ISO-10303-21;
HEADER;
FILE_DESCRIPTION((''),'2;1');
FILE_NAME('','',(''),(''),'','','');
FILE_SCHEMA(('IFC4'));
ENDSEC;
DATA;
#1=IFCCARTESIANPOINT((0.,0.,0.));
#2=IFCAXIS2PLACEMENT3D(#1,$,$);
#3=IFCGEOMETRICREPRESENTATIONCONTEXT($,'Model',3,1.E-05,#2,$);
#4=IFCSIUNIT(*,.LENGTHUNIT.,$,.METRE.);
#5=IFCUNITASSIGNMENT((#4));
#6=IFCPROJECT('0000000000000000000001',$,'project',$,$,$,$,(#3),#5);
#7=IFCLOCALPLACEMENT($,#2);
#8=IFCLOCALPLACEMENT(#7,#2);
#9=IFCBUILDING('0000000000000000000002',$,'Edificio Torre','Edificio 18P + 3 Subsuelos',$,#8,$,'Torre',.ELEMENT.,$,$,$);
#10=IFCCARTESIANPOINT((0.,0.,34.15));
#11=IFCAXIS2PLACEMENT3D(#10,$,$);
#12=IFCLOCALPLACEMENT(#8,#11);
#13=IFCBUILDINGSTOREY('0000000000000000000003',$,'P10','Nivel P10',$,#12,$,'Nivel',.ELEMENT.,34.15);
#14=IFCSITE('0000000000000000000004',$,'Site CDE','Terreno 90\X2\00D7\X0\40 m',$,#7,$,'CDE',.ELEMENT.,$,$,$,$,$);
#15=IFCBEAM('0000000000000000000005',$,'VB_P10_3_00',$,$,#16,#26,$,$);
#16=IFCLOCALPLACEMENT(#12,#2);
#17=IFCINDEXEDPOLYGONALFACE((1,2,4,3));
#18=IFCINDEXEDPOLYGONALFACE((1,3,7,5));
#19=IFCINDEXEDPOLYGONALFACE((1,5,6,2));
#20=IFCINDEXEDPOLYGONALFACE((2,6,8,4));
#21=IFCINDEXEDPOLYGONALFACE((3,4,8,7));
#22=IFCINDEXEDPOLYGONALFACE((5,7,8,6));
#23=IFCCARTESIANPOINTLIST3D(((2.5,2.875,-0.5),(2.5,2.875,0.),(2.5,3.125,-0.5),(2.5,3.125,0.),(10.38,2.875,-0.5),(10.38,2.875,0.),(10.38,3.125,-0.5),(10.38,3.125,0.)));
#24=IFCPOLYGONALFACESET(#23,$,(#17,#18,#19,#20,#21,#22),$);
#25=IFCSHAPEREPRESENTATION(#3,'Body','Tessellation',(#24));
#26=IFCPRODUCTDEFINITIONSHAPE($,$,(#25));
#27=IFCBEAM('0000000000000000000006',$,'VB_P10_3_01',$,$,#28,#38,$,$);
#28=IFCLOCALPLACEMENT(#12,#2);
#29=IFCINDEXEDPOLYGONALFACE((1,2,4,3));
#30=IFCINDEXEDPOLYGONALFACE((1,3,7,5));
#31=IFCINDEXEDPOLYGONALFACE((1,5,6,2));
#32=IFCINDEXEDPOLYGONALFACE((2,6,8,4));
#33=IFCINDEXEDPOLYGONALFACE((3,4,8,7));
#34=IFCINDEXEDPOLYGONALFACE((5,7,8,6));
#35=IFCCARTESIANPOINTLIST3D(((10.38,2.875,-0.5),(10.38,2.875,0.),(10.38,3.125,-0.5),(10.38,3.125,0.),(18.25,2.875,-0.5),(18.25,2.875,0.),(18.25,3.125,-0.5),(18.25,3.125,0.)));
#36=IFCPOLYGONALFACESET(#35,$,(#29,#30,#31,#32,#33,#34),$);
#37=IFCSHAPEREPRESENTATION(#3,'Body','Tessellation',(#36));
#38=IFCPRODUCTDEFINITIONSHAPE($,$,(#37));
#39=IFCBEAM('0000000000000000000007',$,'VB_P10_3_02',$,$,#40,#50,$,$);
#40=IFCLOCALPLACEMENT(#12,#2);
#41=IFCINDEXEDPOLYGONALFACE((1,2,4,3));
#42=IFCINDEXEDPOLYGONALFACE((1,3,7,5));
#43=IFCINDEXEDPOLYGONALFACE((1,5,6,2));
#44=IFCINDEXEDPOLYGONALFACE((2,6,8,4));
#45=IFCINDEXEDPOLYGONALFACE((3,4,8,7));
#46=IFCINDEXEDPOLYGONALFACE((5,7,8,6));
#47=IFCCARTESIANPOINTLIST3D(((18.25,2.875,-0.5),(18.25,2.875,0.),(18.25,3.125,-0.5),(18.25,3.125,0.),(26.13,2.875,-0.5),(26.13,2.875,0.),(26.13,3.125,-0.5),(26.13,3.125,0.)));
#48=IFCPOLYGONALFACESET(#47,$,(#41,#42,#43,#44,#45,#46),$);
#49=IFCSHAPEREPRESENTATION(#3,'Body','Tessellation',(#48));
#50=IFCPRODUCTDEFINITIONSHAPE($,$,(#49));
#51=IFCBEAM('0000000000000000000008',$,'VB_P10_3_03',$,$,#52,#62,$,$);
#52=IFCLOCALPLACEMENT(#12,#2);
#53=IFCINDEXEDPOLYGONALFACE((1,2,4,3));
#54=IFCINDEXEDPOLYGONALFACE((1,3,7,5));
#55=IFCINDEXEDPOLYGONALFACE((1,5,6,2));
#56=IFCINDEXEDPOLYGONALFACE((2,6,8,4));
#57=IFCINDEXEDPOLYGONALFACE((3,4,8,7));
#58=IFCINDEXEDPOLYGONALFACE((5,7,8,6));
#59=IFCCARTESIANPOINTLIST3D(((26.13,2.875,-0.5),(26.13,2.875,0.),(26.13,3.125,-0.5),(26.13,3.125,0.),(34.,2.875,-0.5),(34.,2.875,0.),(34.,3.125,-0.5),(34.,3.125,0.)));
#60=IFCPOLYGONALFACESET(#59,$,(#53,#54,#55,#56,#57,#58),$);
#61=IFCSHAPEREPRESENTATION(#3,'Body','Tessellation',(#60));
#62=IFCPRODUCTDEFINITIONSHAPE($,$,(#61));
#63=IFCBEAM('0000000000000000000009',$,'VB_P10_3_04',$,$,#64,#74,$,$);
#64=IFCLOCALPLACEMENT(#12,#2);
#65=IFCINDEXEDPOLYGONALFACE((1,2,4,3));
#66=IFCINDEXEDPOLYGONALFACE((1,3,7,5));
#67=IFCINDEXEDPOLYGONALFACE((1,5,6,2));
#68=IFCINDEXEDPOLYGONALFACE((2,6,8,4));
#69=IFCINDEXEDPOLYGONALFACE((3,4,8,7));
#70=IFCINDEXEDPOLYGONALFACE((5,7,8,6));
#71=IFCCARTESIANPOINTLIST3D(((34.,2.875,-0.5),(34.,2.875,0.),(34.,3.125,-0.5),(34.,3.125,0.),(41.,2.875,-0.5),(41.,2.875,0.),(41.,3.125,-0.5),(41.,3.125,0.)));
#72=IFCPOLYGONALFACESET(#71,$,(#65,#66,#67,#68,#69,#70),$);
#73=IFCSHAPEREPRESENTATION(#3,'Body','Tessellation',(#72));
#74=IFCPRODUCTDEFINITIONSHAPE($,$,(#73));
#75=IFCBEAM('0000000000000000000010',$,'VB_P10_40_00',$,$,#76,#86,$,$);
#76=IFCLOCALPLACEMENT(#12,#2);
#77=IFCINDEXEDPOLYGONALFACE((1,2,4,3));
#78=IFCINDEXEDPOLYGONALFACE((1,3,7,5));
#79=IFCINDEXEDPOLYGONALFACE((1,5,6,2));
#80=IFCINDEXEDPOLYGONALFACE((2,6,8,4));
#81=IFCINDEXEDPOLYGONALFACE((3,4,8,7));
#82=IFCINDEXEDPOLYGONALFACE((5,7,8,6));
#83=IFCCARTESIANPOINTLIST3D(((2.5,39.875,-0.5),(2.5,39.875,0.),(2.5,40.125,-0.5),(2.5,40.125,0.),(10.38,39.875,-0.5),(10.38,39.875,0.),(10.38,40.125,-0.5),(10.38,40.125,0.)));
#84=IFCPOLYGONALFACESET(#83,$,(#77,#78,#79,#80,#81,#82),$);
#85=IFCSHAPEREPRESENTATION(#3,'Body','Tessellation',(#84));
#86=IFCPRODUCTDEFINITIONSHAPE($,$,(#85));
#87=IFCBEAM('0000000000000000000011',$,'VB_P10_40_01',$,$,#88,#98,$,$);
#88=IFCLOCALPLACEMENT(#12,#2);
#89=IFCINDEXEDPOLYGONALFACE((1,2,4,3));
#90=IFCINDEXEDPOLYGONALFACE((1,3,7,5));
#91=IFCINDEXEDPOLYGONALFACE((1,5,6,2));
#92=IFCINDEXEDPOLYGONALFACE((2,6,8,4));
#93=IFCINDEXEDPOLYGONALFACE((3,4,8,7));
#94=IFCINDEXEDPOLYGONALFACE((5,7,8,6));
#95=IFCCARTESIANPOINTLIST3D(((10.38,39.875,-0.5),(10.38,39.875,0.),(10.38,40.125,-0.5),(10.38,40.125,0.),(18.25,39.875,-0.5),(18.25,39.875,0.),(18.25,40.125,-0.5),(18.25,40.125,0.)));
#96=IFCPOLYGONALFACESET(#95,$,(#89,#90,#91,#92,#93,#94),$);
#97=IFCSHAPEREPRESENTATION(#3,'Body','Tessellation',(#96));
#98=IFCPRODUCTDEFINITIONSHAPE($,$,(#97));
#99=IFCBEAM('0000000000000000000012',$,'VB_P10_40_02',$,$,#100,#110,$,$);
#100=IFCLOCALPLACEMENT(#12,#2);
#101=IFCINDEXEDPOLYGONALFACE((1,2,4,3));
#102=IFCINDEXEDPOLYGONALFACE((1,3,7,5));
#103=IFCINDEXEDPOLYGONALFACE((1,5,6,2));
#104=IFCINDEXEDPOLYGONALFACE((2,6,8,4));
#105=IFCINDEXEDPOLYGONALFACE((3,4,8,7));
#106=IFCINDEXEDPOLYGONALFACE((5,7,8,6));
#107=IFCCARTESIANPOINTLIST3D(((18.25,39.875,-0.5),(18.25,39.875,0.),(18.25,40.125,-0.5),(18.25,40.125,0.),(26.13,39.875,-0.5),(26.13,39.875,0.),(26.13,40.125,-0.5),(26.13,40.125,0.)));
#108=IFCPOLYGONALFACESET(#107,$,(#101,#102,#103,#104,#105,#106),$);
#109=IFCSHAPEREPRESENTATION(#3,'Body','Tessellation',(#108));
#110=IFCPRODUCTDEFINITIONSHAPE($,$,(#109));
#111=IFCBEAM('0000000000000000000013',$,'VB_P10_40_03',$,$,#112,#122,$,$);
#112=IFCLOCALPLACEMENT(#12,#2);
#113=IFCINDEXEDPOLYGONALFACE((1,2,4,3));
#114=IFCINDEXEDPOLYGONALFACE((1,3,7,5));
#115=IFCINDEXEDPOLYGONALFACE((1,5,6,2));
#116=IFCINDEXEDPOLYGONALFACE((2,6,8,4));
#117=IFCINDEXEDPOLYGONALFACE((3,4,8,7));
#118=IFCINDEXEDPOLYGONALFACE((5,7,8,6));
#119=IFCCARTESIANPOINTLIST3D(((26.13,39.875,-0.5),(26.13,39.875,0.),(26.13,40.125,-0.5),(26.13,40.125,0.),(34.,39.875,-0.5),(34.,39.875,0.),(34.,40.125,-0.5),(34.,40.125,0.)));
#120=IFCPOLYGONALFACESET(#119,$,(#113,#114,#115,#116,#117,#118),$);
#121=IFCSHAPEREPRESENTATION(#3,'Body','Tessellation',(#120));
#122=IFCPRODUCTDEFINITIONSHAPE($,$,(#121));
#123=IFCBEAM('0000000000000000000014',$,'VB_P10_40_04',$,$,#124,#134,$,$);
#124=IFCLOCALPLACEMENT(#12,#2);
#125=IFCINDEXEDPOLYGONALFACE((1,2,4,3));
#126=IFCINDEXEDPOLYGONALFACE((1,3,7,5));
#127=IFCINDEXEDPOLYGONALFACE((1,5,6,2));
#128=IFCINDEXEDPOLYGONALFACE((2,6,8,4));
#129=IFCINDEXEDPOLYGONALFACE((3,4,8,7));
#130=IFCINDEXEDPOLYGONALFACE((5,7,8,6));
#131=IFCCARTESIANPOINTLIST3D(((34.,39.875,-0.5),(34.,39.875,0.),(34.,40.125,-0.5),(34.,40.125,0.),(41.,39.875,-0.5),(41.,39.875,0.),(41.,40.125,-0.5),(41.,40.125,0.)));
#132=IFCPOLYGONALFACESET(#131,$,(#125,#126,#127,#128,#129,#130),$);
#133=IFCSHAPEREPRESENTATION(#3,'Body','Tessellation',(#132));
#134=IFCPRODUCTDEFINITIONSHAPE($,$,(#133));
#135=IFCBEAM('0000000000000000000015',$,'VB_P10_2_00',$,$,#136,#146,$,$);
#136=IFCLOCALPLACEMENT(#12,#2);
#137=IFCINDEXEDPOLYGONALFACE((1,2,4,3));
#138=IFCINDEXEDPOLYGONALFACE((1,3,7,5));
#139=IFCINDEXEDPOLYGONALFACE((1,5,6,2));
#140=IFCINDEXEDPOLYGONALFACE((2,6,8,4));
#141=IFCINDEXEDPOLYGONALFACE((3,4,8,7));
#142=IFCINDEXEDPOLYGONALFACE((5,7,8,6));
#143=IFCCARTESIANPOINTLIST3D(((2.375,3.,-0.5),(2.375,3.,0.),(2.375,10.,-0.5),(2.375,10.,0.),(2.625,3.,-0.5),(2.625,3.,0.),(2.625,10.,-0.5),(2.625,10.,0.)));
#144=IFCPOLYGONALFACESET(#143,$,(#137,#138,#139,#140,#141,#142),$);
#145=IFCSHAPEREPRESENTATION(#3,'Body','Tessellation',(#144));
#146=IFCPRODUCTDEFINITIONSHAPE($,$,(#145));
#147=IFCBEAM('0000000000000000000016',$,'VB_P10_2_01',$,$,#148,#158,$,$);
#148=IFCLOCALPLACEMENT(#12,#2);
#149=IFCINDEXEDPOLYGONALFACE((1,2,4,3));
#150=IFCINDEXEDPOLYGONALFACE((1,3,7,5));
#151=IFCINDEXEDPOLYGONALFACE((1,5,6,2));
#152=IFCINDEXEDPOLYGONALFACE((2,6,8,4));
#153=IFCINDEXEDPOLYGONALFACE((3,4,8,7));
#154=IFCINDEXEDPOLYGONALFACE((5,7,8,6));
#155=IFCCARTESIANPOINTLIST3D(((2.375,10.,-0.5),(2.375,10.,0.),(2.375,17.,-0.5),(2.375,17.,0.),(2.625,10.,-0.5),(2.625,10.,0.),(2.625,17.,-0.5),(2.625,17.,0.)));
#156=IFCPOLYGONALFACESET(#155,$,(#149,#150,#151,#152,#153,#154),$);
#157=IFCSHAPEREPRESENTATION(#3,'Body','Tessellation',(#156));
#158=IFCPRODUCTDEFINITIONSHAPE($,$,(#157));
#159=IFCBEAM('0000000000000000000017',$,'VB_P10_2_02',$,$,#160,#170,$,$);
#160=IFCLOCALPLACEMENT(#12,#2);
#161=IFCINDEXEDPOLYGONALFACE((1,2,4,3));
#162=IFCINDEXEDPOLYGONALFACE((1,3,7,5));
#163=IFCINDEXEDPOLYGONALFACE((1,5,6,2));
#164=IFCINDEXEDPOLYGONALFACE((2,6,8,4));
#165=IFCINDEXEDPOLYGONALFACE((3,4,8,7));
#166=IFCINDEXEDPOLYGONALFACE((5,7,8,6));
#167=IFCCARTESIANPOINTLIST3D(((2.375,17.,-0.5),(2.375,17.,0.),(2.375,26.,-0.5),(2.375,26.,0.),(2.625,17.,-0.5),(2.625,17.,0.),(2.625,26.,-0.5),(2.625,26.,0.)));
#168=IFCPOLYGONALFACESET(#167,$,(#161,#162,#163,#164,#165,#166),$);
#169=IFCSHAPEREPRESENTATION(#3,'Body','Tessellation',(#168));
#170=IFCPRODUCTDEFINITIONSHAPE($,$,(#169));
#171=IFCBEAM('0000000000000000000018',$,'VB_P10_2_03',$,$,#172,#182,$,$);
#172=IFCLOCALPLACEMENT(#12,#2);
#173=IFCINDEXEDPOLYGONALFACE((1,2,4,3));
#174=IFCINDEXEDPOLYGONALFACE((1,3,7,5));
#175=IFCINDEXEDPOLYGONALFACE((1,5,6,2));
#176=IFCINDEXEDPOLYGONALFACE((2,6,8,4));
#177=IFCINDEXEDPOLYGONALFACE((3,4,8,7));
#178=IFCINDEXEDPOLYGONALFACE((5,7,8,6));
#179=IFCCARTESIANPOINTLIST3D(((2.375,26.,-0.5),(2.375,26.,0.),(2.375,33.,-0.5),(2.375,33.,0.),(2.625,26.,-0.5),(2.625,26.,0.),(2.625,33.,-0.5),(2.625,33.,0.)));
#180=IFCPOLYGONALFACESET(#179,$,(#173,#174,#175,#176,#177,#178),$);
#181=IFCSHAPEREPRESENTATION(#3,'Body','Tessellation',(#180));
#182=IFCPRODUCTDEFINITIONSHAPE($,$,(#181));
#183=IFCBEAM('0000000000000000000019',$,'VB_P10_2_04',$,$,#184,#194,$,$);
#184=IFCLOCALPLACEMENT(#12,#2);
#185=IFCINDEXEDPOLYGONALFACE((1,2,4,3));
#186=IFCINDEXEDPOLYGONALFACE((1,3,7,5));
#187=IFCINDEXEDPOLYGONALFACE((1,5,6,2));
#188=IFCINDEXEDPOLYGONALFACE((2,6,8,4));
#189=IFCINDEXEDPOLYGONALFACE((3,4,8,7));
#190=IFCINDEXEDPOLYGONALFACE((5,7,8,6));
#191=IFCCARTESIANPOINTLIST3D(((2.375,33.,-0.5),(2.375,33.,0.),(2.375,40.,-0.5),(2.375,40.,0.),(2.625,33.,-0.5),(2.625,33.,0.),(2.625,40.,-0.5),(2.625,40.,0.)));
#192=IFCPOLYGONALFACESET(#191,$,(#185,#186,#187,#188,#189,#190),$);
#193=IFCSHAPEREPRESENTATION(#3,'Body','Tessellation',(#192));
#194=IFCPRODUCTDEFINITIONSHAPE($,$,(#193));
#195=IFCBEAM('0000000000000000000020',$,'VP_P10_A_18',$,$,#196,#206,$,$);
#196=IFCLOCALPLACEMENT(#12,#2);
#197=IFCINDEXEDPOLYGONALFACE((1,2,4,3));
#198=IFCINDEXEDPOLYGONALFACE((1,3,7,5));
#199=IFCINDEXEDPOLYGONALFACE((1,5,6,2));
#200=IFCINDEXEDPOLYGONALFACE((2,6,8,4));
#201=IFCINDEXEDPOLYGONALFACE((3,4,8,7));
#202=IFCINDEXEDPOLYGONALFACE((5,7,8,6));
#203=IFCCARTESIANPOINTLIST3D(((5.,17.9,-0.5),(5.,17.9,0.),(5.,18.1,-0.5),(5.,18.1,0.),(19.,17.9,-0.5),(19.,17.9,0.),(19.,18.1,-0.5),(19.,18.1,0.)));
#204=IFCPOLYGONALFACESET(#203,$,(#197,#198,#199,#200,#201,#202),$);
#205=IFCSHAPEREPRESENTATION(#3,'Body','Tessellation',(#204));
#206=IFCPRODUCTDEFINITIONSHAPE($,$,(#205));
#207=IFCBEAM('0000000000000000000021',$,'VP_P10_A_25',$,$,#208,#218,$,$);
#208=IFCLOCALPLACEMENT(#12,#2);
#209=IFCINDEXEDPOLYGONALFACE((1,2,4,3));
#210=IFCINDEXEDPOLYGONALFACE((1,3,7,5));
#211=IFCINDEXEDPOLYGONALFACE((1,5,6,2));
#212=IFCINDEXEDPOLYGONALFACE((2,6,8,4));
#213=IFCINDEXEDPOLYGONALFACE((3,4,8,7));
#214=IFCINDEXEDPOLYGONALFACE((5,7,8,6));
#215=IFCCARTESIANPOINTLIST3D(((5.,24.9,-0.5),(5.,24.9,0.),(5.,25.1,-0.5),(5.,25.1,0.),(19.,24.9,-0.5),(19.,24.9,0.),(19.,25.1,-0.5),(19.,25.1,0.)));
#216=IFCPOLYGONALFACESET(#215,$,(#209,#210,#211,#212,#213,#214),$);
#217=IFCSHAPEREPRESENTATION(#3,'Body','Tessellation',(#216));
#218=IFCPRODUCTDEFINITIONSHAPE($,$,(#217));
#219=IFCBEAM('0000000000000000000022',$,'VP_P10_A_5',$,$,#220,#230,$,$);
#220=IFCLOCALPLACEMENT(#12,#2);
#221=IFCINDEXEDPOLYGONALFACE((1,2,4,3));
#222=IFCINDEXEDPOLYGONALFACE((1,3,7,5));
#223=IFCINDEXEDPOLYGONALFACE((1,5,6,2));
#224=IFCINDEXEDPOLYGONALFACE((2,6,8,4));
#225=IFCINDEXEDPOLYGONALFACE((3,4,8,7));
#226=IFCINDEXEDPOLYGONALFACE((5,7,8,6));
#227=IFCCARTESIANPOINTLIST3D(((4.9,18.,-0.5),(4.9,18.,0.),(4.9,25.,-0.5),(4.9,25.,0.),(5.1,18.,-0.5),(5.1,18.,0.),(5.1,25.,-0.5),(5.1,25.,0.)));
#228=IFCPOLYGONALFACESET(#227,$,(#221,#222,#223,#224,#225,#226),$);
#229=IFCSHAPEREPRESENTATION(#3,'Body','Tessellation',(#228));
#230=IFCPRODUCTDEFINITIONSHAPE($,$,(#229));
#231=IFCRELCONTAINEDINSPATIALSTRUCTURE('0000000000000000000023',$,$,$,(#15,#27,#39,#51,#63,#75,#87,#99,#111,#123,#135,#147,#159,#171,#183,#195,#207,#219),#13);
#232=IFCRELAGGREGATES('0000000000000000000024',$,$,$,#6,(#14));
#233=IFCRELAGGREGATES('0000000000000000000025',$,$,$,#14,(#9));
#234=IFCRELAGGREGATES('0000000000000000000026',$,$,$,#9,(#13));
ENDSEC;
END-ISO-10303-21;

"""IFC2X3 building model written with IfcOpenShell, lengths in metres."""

from ifc_helpers import new_model, si_unit, frame, origin, origin_2d, place, context, project, spatial, rectangle, extrude, element, save


model = new_model("IFC2X3")

# Units and contexts
model_context = context("Model", 3, precision=1e-05, world=origin())
ifc_project = project(units=[si_unit("LENGTHUNIT", "METRE")], contexts=[model_context])

# Site, building, storey
site_placement = place(None, origin())
site = spatial("IfcSite", under=ifc_project, at=site_placement, Name="Site CDE", Description="Terreno 90×40 m", LongName="CDE", CompositionType="ELEMENT")
building_placement = place(site_placement, origin())
building = spatial("IfcBuilding", under=site, at=building_placement, Name="Edificio Torre", Description="Edificio 18P + 3 Subsuelos", LongName="Torre", CompositionType="ELEMENT")
storey_placement = place(building_placement, frame((0.0, 0.0, 34.15)))
storey = spatial("IfcBuildingStorey", under=building, at=storey_placement, Name="P10", Description="Nivel P10", LongName="Nivel", CompositionType="ELEMENT", Elevation=34.15)

# Beams
beam_1_placement = place(storey_placement, frame((6.44, 3.0, -0.5)))
element("IfcBeam", 1, at=beam_1_placement, inside=storey, Name="VB_P10_3_00", context=model_context, shape_type="SweptSolid", body=[
    extrude(rectangle(XDim=7.88, YDim=0.25, at=origin_2d()), origin(), (0.0, 0.0, 1.0), 0.5),
])
beam_2_placement = place(storey_placement, frame((14.315, 3.0, -0.5)))
element("IfcBeam", 2, at=beam_2_placement, inside=storey, Name="VB_P10_3_01", context=model_context, shape_type="SweptSolid", body=[
    extrude(rectangle(XDim=7.87, YDim=0.25, at=origin_2d()), origin(), (0.0, 0.0, 1.0), 0.5),
])
beam_3_placement = place(storey_placement, frame((22.19, 3.0, -0.5)))
element("IfcBeam", 3, at=beam_3_placement, inside=storey, Name="VB_P10_3_02", context=model_context, shape_type="SweptSolid", body=[
    extrude(rectangle(XDim=7.88, YDim=0.25, at=origin_2d()), origin(), (0.0, 0.0, 1.0), 0.5),
])
beam_4_placement = place(storey_placement, frame((30.065, 3.0, -0.5)))
element("IfcBeam", 4, at=beam_4_placement, inside=storey, Name="VB_P10_3_03", context=model_context, shape_type="SweptSolid", body=[
    extrude(rectangle(XDim=7.87, YDim=0.25, at=origin_2d()), origin(), (0.0, 0.0, 1.0), 0.5),
])
beam_5_placement = place(storey_placement, frame((37.5, 3.0, -0.5)))
element("IfcBeam", 5, at=beam_5_placement, inside=storey, Name="VB_P10_3_04", context=model_context, shape_type="SweptSolid", body=[
    extrude(rectangle(XDim=7.0, YDim=0.25, at=origin_2d()), origin(), (0.0, 0.0, 1.0), 0.5),
])
beam_6_placement = place(storey_placement, frame((6.44, 40.0, -0.5)))
element("IfcBeam", 6, at=beam_6_placement, inside=storey, Name="VB_P10_40_00", context=model_context, shape_type="SweptSolid", body=[
    extrude(rectangle(XDim=7.88, YDim=0.25, at=origin_2d()), origin(), (0.0, 0.0, 1.0), 0.5),
])
beam_7_placement = place(storey_placement, frame((14.315, 40.0, -0.5)))
element("IfcBeam", 7, at=beam_7_placement, inside=storey, Name="VB_P10_40_01", context=model_context, shape_type="SweptSolid", body=[
    extrude(rectangle(XDim=7.87, YDim=0.25, at=origin_2d()), origin(), (0.0, 0.0, 1.0), 0.5),
])
beam_8_placement = place(storey_placement, frame((22.19, 40.0, -0.5)))
element("IfcBeam", 8, at=beam_8_placement, inside=storey, Name="VB_P10_40_02", context=model_context, shape_type="SweptSolid", body=[
    extrude(rectangle(XDim=7.88, YDim=0.25, at=origin_2d()), origin(), (0.0, 0.0, 1.0), 0.5),
])
beam_9_placement = place(storey_placement, frame((30.065, 40.0, -0.5)))
element("IfcBeam", 9, at=beam_9_placement, inside=storey, Name="VB_P10_40_03", context=model_context, shape_type="SweptSolid", body=[
    extrude(rectangle(XDim=7.87, YDim=0.25, at=origin_2d()), origin(), (0.0, 0.0, 1.0), 0.5),
])
beam_10_placement = place(storey_placement, frame((37.5, 40.0, -0.5)))
element("IfcBeam", 10, at=beam_10_placement, inside=storey, Name="VB_P10_40_04", context=model_context, shape_type="SweptSolid", body=[
    extrude(rectangle(XDim=7.0, YDim=0.25, at=origin_2d()), origin(), (0.0, 0.0, 1.0), 0.5),
])
for number, where, name in (
    (11, (2.5, 6.5, -0.5), "VB_P10_2_00"),
    (12, (2.5, 13.5, -0.5), "VB_P10_2_01"),
):
    element("IfcBeam", number, at=place(storey_placement, frame(where)), inside=storey, Name=name, context=model_context, shape_type="SweptSolid", body=[
        extrude(rectangle(XDim=0.25, YDim=7.0, at=origin_2d()), origin(), (0.0, 0.0, 1.0), 0.5),
    ])
beam_11_placement = place(storey_placement, frame((2.5, 21.5, -0.5)))
element("IfcBeam", 13, at=beam_11_placement, inside=storey, Name="VB_P10_2_02", context=model_context, shape_type="SweptSolid", body=[
    extrude(rectangle(XDim=0.25, YDim=9.0, at=origin_2d()), origin(), (0.0, 0.0, 1.0), 0.5),
])
for number, where, name in (
    (14, (2.5, 29.5, -0.5), "VB_P10_2_03"),
    (15, (2.5, 36.5, -0.5), "VB_P10_2_04"),
):
    element("IfcBeam", number, at=place(storey_placement, frame(where)), inside=storey, Name=name, context=model_context, shape_type="SweptSolid", body=[
        extrude(rectangle(XDim=0.25, YDim=7.0, at=origin_2d()), origin(), (0.0, 0.0, 1.0), 0.5),
    ])
for number, where, name in (
    (16, (12.0, 18.0, -0.5), "VP_P10_A_18"),
    (17, (12.0, 25.0, -0.5), "VP_P10_A_25"),
):
    element("IfcBeam", number, at=place(storey_placement, frame(where)), inside=storey, Name=name, context=model_context, shape_type="SweptSolid", body=[
        extrude(rectangle(XDim=14.0, YDim=0.2, at=origin_2d()), origin(), (0.0, 0.0, 1.0), 0.5),
    ])
beam_12_placement = place(storey_placement, frame((5.0, 21.5, -0.5)))
element("IfcBeam", 18, at=beam_12_placement, inside=storey, Name="VP_P10_A_5", context=model_context, shape_type="SweptSolid", body=[
    extrude(rectangle(XDim=0.2, YDim=7.0, at=origin_2d()), origin(), (0.0, 0.0, 1.0), 0.5),
])

save(model, "model.ifc")
